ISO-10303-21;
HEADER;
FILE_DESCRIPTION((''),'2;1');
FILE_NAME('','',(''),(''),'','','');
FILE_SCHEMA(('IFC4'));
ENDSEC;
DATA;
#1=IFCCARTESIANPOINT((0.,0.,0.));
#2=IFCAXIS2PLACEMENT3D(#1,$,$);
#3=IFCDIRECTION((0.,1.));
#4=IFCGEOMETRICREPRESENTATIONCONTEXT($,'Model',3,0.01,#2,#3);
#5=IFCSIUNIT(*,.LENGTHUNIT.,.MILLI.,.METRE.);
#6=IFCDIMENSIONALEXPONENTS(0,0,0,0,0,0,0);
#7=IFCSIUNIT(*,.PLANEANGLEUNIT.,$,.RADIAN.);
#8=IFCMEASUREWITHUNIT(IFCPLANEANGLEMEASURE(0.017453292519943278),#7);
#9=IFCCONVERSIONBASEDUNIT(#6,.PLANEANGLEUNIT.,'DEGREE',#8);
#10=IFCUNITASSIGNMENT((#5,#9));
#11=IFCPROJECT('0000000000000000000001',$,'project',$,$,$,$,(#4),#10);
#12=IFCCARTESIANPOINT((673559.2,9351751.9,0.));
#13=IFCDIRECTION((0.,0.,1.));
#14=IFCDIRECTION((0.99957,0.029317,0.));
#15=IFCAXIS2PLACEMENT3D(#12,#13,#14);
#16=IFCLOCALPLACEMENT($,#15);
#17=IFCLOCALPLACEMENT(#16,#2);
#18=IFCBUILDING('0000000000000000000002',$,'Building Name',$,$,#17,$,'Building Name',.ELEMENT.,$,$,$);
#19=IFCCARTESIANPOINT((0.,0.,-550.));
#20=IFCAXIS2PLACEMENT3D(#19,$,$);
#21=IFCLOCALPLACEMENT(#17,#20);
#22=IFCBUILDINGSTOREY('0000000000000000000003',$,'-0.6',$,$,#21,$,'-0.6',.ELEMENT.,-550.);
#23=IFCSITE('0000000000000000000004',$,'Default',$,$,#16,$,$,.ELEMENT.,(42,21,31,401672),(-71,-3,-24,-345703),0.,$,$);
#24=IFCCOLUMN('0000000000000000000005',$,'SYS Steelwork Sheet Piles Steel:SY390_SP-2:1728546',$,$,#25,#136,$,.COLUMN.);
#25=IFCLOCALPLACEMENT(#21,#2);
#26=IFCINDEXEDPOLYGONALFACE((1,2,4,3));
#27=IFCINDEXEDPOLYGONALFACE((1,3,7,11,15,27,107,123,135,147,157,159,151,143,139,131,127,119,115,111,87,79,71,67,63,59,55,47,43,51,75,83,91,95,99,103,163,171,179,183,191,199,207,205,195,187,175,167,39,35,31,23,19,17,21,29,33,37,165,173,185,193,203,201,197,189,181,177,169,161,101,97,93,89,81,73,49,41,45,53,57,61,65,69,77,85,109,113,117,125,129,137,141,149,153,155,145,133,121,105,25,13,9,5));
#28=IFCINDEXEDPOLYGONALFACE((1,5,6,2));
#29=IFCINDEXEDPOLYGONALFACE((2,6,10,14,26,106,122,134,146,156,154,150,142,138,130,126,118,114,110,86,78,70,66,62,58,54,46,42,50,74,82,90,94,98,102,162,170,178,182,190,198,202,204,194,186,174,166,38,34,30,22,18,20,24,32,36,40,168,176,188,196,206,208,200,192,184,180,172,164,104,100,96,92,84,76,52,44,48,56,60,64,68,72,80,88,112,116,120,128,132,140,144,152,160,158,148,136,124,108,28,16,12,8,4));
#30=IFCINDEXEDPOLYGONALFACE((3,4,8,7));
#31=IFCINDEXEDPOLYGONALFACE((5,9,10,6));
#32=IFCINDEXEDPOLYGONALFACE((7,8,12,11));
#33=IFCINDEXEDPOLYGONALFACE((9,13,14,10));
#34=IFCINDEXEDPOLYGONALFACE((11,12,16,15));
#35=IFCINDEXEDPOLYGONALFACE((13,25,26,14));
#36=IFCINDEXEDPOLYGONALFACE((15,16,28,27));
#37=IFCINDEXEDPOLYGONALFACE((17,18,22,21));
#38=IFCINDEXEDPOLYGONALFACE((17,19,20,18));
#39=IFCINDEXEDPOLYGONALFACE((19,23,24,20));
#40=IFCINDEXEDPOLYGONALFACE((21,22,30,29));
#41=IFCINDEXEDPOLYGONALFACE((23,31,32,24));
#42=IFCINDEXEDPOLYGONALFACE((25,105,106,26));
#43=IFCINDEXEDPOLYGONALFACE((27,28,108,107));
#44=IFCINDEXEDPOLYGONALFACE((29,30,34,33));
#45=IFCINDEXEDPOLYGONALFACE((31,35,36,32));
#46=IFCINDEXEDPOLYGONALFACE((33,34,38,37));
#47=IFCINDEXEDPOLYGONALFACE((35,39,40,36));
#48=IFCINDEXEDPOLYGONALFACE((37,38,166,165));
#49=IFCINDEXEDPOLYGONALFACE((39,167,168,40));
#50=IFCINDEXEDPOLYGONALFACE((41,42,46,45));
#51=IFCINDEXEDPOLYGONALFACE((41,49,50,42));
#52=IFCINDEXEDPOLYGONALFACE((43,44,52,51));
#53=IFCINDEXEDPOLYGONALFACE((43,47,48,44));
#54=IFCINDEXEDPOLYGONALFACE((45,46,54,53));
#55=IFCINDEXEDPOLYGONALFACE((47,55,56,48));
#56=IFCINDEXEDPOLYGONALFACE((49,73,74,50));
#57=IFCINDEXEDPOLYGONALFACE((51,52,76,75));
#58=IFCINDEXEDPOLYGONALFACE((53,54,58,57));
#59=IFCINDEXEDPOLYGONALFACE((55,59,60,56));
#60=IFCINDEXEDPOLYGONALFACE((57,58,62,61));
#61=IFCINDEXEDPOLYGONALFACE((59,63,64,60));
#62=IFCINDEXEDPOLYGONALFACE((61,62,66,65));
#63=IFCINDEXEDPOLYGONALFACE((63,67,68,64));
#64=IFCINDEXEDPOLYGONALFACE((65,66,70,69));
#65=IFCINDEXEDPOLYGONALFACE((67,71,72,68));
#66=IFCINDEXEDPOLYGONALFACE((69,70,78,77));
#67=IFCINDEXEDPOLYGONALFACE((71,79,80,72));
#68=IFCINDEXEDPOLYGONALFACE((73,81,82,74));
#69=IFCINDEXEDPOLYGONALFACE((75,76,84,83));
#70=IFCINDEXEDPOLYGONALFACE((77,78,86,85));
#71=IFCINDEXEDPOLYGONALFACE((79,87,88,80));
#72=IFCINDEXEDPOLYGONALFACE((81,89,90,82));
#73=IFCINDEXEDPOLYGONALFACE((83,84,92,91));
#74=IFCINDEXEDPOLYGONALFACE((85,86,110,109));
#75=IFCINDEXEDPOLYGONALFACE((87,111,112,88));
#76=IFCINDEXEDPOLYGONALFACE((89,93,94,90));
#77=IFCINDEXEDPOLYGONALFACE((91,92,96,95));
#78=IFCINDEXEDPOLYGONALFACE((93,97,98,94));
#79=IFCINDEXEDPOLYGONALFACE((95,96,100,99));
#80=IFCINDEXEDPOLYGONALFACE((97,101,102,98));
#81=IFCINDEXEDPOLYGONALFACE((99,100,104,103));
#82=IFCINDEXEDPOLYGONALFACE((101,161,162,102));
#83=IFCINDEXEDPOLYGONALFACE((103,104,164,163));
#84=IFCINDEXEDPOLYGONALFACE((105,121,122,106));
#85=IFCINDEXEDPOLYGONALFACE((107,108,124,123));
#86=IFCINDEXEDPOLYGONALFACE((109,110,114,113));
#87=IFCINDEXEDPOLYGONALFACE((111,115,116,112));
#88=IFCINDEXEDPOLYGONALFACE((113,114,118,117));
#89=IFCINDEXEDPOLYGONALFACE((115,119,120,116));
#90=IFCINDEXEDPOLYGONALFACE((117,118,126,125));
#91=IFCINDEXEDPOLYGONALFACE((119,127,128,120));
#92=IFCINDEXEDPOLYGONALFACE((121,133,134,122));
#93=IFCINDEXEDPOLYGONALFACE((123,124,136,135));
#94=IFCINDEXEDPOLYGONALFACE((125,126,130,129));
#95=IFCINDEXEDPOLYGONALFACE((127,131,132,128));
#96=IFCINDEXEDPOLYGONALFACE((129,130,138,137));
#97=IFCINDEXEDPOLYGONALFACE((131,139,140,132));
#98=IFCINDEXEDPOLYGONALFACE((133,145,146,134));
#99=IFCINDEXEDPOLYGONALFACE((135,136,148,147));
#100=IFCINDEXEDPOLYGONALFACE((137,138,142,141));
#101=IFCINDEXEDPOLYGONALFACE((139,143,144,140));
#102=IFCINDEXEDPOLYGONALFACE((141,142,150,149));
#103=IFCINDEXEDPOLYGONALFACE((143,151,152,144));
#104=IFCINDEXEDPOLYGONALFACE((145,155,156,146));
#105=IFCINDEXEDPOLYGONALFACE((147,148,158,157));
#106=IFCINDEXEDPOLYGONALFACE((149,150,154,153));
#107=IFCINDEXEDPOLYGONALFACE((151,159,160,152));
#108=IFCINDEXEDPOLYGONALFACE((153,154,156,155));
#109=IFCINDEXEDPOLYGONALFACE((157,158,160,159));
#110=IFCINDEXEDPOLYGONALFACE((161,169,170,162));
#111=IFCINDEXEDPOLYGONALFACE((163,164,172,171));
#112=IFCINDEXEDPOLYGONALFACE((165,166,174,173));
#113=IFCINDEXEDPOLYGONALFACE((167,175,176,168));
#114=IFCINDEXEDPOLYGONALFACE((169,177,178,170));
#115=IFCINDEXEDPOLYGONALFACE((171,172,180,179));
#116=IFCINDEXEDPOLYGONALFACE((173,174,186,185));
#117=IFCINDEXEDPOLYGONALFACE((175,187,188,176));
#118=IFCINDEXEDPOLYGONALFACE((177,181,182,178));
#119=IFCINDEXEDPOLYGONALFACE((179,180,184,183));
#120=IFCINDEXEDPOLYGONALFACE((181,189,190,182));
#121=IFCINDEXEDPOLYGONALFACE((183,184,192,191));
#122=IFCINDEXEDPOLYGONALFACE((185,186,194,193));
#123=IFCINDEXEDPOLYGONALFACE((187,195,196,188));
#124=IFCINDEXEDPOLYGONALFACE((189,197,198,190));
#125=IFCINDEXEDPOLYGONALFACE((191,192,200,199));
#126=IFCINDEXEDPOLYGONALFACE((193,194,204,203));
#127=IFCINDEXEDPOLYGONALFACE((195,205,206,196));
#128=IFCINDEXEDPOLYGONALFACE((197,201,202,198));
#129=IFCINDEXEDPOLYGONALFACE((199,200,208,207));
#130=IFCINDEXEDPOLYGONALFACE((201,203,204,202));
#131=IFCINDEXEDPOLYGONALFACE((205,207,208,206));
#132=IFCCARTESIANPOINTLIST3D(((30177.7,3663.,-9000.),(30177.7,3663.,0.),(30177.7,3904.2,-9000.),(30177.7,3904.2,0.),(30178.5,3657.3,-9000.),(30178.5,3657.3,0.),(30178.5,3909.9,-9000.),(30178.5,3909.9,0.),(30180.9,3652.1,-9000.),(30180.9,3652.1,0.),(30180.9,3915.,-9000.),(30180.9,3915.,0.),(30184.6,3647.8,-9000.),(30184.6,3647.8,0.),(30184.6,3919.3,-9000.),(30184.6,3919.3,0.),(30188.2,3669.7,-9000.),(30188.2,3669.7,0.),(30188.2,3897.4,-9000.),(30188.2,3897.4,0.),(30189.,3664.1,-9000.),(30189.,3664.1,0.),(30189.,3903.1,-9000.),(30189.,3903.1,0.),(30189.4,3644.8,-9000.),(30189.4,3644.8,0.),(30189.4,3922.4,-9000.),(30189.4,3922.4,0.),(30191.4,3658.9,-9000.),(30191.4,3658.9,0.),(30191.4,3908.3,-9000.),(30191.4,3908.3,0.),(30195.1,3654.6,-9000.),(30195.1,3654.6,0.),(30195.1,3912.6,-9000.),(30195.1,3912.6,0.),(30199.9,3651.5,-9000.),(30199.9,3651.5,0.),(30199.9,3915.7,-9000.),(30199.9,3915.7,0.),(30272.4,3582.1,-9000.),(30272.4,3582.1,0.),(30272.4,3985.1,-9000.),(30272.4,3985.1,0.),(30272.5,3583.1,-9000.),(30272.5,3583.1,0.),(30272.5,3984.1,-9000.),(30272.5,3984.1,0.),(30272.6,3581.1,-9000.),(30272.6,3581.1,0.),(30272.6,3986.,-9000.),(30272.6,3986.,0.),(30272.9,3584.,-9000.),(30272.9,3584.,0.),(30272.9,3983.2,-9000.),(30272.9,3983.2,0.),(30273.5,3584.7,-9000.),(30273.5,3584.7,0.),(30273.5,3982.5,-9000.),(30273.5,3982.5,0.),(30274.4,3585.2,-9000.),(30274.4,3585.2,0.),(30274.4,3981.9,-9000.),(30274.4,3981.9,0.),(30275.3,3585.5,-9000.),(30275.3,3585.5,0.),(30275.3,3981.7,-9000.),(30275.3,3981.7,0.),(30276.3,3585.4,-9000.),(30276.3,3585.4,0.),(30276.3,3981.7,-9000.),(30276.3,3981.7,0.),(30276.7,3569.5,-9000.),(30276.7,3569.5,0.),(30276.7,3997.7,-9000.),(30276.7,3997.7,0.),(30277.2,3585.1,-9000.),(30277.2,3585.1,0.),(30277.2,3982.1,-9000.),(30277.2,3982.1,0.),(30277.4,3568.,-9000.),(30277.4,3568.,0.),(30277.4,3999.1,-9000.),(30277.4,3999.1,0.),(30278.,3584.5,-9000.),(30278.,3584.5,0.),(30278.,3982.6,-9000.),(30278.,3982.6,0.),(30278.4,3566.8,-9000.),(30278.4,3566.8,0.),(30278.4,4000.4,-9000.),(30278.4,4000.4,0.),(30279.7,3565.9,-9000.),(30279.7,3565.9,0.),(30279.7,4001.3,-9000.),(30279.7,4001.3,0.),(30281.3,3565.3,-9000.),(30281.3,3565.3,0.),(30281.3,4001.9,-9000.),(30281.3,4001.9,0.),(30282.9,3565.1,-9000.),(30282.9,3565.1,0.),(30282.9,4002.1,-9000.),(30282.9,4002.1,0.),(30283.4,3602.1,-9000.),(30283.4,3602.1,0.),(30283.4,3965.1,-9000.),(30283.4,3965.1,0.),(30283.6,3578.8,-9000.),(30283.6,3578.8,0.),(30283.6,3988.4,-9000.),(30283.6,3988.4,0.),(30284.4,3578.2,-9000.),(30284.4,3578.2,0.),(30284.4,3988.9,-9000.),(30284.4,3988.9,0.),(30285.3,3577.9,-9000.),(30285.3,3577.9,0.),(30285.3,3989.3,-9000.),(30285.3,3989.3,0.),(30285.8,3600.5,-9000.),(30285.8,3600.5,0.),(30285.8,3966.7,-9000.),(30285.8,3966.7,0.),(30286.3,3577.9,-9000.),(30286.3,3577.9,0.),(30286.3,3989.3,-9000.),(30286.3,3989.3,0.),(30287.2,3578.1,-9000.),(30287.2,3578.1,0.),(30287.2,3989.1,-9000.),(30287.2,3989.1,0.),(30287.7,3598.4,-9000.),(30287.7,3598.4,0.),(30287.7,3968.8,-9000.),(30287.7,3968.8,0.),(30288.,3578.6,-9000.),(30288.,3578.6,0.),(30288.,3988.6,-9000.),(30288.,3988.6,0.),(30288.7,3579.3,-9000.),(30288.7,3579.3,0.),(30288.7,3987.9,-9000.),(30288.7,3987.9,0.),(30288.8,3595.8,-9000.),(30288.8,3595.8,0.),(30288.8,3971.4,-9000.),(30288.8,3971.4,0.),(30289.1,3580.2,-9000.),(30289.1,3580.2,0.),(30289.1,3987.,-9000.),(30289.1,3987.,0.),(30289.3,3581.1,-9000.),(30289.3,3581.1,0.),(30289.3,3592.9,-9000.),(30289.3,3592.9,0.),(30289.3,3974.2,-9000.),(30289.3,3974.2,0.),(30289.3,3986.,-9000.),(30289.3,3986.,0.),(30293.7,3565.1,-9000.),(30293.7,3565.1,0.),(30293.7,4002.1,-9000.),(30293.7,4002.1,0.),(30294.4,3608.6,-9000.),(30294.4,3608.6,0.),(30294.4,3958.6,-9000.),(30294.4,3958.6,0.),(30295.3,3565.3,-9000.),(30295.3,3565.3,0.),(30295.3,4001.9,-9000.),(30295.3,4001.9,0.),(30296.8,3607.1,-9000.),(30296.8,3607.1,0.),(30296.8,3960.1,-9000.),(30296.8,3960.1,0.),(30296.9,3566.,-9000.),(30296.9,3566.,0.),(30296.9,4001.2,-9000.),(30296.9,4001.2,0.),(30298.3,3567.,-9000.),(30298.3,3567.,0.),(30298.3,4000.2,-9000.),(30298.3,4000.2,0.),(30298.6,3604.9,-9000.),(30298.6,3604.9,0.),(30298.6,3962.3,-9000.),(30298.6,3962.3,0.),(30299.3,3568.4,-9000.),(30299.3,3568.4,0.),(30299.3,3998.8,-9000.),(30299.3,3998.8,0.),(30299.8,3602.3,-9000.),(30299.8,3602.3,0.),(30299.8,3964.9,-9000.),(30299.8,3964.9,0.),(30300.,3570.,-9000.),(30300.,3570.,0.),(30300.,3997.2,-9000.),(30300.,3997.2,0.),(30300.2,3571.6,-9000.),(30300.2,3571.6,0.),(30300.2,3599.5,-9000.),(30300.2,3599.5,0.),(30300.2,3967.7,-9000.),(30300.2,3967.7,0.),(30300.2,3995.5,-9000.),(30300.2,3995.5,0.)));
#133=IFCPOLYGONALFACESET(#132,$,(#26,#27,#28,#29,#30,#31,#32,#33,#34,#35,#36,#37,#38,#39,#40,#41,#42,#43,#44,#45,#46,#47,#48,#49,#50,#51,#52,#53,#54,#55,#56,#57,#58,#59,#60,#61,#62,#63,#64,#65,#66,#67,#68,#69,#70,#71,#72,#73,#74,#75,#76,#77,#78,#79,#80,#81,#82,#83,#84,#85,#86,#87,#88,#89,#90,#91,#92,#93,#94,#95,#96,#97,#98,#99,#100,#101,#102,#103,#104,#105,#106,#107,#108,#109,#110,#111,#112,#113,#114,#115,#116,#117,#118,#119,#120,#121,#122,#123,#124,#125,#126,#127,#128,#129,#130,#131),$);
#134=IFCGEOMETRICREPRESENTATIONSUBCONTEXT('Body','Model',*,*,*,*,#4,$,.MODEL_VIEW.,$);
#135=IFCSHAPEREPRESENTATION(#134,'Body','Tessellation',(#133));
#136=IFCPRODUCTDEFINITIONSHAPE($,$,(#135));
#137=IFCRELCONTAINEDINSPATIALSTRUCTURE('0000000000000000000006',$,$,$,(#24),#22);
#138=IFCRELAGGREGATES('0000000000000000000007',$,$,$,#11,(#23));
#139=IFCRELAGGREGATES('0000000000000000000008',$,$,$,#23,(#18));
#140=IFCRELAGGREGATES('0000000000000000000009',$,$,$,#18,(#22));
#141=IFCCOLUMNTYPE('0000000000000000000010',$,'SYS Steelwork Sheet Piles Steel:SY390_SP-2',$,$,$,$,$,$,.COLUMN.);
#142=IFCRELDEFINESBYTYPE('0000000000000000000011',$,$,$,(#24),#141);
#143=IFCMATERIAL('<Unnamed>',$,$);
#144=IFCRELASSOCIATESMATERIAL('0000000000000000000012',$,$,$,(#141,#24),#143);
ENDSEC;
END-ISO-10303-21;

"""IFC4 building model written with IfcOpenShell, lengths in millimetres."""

from ifc_helpers import new_model, entity, si_unit, converted_unit, direction, frame, origin, place, context, subcontext, project, spatial, line, arc, indexed_curve, outline, extrude, source, transform, mapped, material, type_object, type_shapes, element, save


model = new_model("IFC4")

# Units and contexts
model_context = context("Model", 3, precision=0.01, world=origin(), true_north=direction((0.0, 1.0)))
body_context = subcontext(model_context, "Body", "Model", "MODEL_VIEW")
ifc_project = project(units=[si_unit("LENGTHUNIT", "METRE", prefix="MILLI"), converted_unit("PLANEANGLEUNIT", "DEGREE", entity("IfcPlaneAngleMeasure", 0.017453292519943278), si_unit("PLANEANGLEUNIT", "RADIAN"), dimensions=[0, 0, 0, 0, 0, 0, 0])], contexts=[model_context])

# Site, building, storey
site_placement = place(None, frame((673559.2, 9351751.9, 0.0), z_axis=(0.0, 0.0, 1.0), x_axis=(0.99957, 0.029317, 0.0)))
site = spatial("IfcSite", under=ifc_project, at=site_placement, Name="Default", CompositionType="ELEMENT", RefLatitude=(42, 21, 31, 401672), RefLongitude=(-71, -3, -24, -345703), RefElevation=0.0)
building_placement = place(site_placement, origin())
building = spatial("IfcBuilding", under=site, at=building_placement, Name="Building Name", LongName="Building Name", CompositionType="ELEMENT")
storey_placement = place(building_placement, frame((0.0, 0.0, -550.0)))
storey = spatial("IfcBuildingStorey", under=building, at=storey_placement, Name="-0.6", LongName="-0.6", CompositionType="ELEMENT", Elevation=-550.0)

# Column
ifc_material_1 = material(Name="<Unnamed>")
column_type = type_object("IfcColumnType", Name="SYS Steelwork Sheet Piles Steel:SY390_SP-2", PredefinedType="COLUMN", material=ifc_material_1)
shared_shape_1 = source(origin(), body_context, "Body", "SweptSolid", [
    extrude(outline(indexed_curve([(-120.6, 84.7), (-131.4, 81.6), (-138.8, 73.0), (-181.5, -20.9), (-185.2, -25.2), (-190.6, -26.8), (-202.5, -26.8), (-205.5, -24.8), (-204.8, -21.2), (-199.1, -15.5), (-198.6, -11.5), (-202.5, -10.1), (-214.1, -14.2), (-217.3, -16.6), (-218.5, -20.4), (-218.5, -31.2), (-216.6, -35.8), (-211.9, -37.8), (-184.1, -37.8), (-178.7, -36.2), (-175.0, -31.9), (-132.1, 62.5), (-124.7, 71.1), (-113.9, 74.2), (113.9, 74.2), (124.7, 71.1), (132.1, 62.5), (175.0, -31.9), (178.7, -36.2), (184.1, -37.8), (211.9, -37.8), (216.6, -35.8), (218.5, -31.2), (218.5, -20.4), (217.3, -16.6), (214.1, -14.2), (202.5, -10.1), (198.6, -11.5), (199.1, -15.5), (204.8, -21.2), (205.5, -24.8), (202.5, -26.8), (190.6, -26.8), (185.2, -25.2), (181.5, -20.9), (138.8, 73.0), (131.4, 81.6), (120.6, 84.7)], segments=[arc(1, 2, 3), line(3, 4), arc(4, 5, 6), line(6, 7), arc(7, 8, 9), line(9, 10), arc(10, 11, 12), line(12, 13), arc(13, 14, 15), line(15, 16), arc(16, 17, 18), line(18, 19), arc(19, 20, 21), line(21, 22), arc(22, 23, 24), line(24, 25), arc(25, 26, 27), line(27, 28), arc(28, 29, 30), line(30, 31), arc(31, 32, 33), line(33, 34), arc(34, 35, 36), line(36, 37), arc(37, 38, 39), line(39, 40), arc(40, 41, 42), line(42, 43), arc(43, 44, 45), line(45, 46), arc(46, 47, 48), line(48, 1)], self_intersect=False)), frame((0.0, 15.3, -9550.0)), (0.0, 0.0, 1.0), 9000.0),
])
type_shapes(column_type, [shared_shape_1])
for number, where, z_axis, x_axis, name in (
    (1, (30277.7, 3783.6, 550.0), (0.0, 0.0, 1.0), (0.0, 1.0, 0.0), "SYS Steelwork Sheet Piles Steel:SY390_SP-2:1728546"),
):
    element("IfcColumn", number, at=place(storey_placement, frame(where, z_axis=z_axis, x_axis=x_axis)), inside=storey, type_object=column_type, material=ifc_material_1, Name=name, PredefinedType="COLUMN", context=body_context, shape_type="MappedRepresentation", body=[
        mapped(shared_shape_1, transform((0.0, 0.0, 0.0), scale=1.0)),
    ])

save(model, "model.ifc")
